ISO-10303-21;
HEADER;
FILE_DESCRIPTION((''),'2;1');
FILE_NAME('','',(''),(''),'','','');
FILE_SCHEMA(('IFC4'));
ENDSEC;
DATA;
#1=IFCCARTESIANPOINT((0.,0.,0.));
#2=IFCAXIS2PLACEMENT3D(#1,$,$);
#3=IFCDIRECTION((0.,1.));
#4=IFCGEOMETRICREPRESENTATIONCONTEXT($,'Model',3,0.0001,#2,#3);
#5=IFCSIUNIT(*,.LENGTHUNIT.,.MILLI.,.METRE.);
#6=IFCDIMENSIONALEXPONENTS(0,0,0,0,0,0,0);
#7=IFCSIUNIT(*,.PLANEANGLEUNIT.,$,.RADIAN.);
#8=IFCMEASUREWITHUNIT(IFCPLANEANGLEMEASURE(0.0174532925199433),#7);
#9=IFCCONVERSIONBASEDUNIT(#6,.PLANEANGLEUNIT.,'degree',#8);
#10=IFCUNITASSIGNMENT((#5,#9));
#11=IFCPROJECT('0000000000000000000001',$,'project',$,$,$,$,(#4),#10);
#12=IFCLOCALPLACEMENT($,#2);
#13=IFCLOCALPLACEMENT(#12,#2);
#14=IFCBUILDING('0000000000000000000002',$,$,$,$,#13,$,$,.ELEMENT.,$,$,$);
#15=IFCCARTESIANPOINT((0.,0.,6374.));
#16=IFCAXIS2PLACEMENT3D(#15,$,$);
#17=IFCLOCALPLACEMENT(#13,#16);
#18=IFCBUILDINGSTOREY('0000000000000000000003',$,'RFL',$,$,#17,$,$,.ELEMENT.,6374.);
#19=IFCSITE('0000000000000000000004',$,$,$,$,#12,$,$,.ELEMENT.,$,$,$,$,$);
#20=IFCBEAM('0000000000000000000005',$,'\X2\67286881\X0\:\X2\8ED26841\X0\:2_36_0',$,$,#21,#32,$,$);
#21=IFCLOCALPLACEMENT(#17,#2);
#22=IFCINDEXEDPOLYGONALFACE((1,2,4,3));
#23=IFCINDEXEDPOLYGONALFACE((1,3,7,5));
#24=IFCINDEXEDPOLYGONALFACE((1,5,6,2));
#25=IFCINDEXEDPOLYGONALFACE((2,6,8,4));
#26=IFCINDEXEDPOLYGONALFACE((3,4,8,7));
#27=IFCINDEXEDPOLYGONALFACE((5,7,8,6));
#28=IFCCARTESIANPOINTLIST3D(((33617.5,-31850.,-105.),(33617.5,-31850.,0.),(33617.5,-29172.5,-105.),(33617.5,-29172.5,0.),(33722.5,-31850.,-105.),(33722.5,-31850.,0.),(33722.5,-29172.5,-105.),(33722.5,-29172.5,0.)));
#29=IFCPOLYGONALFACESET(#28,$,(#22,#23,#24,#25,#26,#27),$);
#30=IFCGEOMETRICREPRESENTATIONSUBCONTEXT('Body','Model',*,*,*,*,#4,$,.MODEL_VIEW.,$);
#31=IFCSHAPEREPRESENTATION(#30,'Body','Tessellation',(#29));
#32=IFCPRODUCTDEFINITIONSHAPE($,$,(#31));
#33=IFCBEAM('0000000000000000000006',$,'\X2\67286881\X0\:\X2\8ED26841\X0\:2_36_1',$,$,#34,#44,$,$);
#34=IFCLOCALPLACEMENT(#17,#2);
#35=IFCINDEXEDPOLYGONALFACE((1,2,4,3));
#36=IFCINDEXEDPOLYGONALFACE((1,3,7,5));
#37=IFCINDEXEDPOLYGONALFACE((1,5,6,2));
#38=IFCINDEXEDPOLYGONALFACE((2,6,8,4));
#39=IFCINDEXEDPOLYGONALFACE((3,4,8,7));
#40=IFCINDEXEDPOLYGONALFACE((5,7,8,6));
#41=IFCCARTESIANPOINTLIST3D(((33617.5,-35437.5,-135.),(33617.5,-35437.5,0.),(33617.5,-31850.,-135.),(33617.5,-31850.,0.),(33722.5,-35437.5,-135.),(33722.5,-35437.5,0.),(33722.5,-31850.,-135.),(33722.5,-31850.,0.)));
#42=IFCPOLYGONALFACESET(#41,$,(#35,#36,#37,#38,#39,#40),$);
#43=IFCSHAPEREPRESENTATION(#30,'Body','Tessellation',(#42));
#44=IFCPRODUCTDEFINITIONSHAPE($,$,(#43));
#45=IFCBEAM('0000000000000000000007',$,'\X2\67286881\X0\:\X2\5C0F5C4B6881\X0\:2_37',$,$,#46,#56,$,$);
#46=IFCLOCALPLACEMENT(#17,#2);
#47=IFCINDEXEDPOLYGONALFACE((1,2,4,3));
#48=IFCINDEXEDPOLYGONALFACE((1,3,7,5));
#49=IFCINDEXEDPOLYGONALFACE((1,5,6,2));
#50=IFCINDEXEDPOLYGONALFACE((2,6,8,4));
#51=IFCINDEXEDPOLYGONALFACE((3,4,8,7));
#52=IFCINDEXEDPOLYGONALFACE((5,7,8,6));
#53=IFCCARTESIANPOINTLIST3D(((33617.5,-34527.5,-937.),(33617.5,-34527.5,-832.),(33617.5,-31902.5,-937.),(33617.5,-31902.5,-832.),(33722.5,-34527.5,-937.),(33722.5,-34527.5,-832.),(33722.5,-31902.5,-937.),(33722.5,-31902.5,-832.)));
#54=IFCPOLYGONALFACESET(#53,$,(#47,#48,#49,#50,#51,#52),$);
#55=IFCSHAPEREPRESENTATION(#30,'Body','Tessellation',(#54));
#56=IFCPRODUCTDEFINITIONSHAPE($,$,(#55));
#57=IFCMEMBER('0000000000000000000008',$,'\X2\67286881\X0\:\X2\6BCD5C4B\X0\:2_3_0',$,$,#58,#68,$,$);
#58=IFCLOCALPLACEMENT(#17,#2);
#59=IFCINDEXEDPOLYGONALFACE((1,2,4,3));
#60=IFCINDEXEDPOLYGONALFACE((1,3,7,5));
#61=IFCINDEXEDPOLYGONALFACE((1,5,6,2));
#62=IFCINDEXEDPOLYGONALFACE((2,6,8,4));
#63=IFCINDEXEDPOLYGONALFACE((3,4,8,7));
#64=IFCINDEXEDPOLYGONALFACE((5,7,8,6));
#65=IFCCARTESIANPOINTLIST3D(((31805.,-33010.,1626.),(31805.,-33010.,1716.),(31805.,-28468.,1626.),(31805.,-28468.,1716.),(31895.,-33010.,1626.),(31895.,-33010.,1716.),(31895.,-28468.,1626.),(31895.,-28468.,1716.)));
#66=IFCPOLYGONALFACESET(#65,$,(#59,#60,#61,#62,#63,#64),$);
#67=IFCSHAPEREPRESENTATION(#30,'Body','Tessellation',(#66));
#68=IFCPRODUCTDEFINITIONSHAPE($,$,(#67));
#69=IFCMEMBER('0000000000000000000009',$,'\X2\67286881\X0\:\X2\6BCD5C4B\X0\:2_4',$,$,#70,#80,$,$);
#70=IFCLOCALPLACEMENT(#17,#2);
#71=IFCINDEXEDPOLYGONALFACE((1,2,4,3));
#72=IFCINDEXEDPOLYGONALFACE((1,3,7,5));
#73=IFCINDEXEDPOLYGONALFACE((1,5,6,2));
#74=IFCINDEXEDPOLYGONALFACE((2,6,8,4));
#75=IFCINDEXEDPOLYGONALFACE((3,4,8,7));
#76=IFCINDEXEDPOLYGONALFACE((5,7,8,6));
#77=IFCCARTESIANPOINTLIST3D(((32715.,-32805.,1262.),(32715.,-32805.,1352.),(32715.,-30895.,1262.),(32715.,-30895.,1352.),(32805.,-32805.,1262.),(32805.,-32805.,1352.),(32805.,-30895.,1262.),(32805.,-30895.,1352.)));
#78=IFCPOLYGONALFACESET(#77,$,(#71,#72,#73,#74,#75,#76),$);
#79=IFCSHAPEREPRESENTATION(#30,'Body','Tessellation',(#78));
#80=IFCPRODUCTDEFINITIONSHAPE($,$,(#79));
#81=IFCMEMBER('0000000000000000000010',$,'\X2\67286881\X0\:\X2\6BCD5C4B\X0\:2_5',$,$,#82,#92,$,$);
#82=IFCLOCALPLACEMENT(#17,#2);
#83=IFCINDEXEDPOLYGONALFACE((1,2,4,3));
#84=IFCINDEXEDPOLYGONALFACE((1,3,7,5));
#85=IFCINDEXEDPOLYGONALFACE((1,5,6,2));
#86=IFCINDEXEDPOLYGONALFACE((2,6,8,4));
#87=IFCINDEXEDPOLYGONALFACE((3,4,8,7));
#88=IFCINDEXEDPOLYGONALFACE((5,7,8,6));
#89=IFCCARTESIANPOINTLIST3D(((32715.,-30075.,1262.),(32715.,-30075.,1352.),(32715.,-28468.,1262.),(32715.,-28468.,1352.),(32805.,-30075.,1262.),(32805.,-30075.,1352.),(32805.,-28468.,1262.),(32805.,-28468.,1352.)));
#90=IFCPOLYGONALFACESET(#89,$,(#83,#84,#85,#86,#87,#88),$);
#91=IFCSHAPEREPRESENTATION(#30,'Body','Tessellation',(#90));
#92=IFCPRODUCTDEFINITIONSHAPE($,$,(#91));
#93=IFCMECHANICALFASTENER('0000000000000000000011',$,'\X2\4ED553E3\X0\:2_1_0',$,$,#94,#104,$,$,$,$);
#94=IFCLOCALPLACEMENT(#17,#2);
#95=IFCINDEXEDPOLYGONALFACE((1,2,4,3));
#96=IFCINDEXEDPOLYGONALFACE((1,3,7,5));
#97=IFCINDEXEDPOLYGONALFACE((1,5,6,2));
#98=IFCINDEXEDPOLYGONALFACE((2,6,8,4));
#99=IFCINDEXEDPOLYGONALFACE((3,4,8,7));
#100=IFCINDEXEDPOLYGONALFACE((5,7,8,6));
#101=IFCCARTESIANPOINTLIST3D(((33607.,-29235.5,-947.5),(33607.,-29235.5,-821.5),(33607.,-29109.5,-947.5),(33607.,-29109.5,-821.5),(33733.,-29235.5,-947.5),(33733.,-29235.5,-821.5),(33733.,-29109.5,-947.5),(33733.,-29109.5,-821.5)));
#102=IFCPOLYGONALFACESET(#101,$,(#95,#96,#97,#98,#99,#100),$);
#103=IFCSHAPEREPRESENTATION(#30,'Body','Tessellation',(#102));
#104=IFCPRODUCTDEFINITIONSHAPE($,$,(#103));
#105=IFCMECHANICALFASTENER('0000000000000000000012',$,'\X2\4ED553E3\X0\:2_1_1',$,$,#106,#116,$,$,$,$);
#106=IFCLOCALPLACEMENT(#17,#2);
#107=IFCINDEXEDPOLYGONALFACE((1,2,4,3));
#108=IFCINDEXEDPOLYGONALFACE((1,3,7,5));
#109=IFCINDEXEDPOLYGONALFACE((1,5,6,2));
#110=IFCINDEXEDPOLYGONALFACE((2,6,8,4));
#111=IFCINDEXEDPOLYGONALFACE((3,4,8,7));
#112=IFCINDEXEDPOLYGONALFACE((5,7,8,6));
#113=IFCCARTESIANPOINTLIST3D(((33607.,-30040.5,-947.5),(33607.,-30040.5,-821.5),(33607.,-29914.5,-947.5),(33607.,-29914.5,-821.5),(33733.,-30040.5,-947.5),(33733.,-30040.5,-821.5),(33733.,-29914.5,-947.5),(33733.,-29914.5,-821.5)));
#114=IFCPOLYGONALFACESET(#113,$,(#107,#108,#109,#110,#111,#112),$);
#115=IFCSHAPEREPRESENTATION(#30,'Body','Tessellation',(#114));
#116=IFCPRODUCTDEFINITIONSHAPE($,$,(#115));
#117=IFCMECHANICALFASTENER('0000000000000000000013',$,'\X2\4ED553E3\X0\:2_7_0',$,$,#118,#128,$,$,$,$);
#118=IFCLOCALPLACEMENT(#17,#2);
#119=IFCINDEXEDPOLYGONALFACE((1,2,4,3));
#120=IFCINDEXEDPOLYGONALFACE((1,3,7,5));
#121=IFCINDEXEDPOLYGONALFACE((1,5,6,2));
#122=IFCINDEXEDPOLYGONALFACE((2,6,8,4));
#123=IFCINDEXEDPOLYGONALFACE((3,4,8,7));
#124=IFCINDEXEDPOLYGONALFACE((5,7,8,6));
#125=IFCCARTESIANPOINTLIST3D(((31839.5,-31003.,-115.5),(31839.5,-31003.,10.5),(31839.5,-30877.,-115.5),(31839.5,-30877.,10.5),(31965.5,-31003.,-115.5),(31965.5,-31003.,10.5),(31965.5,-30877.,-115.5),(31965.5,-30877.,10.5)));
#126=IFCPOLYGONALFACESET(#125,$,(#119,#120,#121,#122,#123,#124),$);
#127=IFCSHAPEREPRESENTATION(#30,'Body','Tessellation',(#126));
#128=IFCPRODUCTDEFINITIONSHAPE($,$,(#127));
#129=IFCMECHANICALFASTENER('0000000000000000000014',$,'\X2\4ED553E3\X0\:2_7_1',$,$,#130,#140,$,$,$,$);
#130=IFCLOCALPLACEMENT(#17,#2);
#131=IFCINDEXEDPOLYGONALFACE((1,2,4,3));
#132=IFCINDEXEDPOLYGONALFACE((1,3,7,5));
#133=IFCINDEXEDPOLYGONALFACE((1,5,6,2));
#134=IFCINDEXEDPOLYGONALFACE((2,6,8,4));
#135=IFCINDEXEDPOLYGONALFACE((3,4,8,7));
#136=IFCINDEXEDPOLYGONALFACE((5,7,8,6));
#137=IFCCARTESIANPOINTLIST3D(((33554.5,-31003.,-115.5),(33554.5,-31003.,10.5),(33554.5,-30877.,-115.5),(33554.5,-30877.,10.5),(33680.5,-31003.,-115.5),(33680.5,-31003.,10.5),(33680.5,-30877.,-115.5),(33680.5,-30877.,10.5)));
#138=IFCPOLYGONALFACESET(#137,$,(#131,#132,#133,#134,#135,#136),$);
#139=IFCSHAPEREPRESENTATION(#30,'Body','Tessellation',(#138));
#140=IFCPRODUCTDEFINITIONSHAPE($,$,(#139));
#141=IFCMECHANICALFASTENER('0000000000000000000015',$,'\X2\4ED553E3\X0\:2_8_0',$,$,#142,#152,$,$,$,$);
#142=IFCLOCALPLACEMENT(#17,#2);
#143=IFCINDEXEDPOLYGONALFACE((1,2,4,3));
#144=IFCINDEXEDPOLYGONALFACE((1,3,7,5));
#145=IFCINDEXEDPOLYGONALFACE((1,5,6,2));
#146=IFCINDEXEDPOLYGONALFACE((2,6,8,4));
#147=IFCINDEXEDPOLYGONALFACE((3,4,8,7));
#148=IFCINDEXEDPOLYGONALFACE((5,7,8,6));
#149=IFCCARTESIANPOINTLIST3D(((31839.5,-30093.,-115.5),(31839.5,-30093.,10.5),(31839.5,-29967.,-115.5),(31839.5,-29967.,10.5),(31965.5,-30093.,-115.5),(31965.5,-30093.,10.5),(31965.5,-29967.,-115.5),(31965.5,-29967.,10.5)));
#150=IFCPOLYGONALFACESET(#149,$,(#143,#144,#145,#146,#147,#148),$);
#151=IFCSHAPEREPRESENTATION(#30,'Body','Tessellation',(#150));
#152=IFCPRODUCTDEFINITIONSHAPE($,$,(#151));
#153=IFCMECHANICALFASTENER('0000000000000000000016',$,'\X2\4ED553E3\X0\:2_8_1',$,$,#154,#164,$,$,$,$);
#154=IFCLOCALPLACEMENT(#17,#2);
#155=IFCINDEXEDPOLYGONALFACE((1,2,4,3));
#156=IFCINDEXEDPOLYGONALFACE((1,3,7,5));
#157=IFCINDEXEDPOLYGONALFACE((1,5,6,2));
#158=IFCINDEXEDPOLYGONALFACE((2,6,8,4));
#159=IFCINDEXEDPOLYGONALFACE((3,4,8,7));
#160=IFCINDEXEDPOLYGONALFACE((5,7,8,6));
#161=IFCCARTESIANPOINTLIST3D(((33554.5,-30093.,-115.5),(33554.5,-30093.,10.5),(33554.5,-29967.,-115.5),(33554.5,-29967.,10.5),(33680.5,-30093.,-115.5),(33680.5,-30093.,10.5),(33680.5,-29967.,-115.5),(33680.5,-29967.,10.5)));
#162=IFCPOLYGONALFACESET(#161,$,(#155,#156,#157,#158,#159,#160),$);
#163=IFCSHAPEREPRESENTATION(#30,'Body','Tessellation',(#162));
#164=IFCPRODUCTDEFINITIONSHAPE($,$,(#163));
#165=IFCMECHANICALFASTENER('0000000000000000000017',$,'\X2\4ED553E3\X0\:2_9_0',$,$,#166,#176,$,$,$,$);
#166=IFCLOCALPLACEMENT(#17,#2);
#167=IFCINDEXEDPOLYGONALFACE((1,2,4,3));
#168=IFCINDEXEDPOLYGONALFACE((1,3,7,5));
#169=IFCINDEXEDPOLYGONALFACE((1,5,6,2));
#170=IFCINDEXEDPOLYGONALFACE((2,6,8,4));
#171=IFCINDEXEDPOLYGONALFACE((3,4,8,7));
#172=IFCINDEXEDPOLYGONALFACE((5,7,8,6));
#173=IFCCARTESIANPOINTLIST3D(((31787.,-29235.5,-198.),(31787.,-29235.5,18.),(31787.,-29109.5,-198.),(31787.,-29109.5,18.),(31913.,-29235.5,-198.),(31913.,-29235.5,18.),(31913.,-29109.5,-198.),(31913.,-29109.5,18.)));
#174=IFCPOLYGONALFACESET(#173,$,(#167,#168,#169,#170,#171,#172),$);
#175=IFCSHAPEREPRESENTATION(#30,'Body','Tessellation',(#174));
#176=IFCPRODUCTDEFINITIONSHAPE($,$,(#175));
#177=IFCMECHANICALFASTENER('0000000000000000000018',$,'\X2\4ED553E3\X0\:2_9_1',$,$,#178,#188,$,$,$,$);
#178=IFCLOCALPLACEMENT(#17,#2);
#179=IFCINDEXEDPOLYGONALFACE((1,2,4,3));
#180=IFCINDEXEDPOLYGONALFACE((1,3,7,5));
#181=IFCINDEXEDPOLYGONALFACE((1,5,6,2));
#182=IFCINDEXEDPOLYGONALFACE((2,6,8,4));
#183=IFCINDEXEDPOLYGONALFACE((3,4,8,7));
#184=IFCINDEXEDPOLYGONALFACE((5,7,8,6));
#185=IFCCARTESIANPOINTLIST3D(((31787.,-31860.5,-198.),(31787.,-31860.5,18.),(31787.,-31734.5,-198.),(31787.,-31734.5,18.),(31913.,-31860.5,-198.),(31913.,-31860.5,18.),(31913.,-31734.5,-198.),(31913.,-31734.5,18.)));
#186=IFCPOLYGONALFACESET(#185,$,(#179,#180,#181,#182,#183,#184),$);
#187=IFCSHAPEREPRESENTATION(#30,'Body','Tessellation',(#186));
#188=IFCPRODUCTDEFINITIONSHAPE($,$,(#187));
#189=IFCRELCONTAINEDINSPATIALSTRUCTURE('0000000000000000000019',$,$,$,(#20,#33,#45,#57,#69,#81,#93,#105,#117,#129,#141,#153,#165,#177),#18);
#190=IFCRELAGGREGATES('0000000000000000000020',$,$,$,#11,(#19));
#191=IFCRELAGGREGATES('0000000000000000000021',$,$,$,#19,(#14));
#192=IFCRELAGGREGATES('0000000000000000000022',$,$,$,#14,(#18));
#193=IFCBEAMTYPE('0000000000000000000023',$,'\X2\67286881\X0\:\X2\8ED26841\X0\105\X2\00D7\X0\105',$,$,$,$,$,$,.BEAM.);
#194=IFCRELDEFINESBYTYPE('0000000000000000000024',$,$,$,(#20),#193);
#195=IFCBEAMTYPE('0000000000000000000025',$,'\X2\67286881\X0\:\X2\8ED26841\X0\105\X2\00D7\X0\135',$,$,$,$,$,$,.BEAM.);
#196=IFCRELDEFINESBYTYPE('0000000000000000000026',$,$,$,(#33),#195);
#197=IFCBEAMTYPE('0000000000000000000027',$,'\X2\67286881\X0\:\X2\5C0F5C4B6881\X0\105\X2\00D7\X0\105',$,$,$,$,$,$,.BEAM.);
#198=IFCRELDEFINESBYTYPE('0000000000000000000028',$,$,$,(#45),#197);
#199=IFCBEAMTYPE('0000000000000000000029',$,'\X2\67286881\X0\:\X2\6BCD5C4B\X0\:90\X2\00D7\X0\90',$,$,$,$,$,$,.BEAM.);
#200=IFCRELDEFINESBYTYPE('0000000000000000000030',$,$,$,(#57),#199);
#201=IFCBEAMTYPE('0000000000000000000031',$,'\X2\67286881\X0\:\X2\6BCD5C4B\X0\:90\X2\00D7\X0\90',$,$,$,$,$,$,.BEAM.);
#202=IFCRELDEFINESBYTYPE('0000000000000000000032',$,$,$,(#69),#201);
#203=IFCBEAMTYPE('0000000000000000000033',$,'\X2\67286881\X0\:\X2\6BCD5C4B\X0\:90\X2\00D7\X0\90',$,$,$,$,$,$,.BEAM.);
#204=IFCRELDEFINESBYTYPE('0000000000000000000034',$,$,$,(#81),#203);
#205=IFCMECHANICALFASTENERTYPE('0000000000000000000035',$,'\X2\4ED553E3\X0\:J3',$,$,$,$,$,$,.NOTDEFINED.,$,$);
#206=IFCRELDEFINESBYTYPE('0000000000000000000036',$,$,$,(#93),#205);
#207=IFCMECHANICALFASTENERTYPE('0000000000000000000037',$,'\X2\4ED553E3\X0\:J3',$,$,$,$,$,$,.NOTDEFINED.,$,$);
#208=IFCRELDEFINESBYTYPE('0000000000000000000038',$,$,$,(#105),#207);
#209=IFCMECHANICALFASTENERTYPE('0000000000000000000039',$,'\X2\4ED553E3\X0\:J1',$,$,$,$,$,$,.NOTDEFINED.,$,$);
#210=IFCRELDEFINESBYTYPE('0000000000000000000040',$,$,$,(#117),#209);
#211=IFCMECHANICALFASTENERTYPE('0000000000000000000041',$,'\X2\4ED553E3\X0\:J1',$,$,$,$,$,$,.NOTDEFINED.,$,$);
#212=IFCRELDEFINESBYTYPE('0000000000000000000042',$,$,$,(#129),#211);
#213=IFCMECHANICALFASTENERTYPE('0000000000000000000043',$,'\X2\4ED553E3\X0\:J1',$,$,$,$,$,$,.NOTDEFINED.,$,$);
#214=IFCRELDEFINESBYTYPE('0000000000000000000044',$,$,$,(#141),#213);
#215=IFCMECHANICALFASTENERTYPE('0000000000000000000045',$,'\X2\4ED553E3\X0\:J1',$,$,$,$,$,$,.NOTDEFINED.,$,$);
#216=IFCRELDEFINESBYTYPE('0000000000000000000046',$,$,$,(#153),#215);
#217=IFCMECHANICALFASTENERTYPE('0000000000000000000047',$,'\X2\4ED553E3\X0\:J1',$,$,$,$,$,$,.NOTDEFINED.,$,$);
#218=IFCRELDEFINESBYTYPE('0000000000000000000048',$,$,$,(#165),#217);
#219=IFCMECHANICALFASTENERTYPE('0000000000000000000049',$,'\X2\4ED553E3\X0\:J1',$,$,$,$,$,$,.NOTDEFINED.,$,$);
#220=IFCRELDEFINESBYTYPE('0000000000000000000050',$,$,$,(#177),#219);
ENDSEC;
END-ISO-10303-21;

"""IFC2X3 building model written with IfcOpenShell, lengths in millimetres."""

from ifc_helpers import new_model, entity, si_unit, converted_unit, direction, frame, origin, origin_with_axes, origin_2d, place, context, subcontext, project, spatial, rectangle, extrude, type_object, element, save


model = new_model("IFC2X3")

# Units and contexts
model_context = context("Model", 3, precision=0.0001, world=origin(), true_north=direction((0.0, 1.0)))
body_context = subcontext(model_context, "Body", "Model", "MODEL_VIEW")
ifc_project = project(units=[si_unit("LENGTHUNIT", "METRE", prefix="MILLI"), converted_unit("PLANEANGLEUNIT", "degree", entity("IfcPlaneAngleMeasure", 0.0174532925199433), si_unit("PLANEANGLEUNIT", "RADIAN"), dimensions=[0, 0, 0, 0, 0, 0, 0])], contexts=[model_context])

# Site, building, storey
site_placement = place(None, origin())
site = spatial("IfcSite", under=ifc_project, at=site_placement, CompositionType="ELEMENT")
building_placement = place(site_placement, origin())
building = spatial("IfcBuilding", under=site, at=building_placement, CompositionType="ELEMENT")
storey_placement = place(building_placement, frame((0.0, 0.0, 6374.0)))
storey = spatial("IfcBuildingStorey", under=building, at=storey_placement, Name="RFL", CompositionType="ELEMENT", Elevation=6374.0)

# Beams
beam_type_1 = type_object("IfcBeamType", Name="木梁:軒桁105×105", PredefinedType="BEAM")
beam_1_placement = place(storey_placement, frame((33670.0, -29172.5, -52.5), z_axis=(0.0, -1.0, 0.0), x_axis=(1.0, 0.0, 0.0)))
element("IfcBeam", 1, at=beam_1_placement, inside=storey, type_object=beam_type_1, Name="木梁:軒桁:2_36_0", context=body_context, shape_type="SweptSolid", body=[
    extrude(rectangle(XDim=105.0, YDim=105.0, at=origin_2d()), origin_with_axes(), (0.0, 0.0, 1.0), 2677.5),
])
beam_type_2 = type_object("IfcBeamType", Name="木梁:軒桁105×135", PredefinedType="BEAM")
beam_2_placement = place(storey_placement, frame((33670.0, -31850.0, -67.5), z_axis=(0.0, -1.0, 0.0), x_axis=(1.0, 0.0, 0.0)))
element("IfcBeam", 2, at=beam_2_placement, inside=storey, type_object=beam_type_2, Name="木梁:軒桁:2_36_1", context=body_context, shape_type="SweptSolid", body=[
    extrude(rectangle(XDim=105.0, YDim=135.0, at=origin_2d()), origin_with_axes(), (0.0, 0.0, 1.0), 3587.5),
])
beam_type_3 = type_object("IfcBeamType", Name="木梁:小屋梁105×105", PredefinedType="BEAM")
beam_3_placement = place(storey_placement, frame((33670.0, -31902.5, -884.5), z_axis=(0.0, -1.0, 0.0), x_axis=(1.0, 0.0, 0.0)))
element("IfcBeam", 3, at=beam_3_placement, inside=storey, type_object=beam_type_3, Name="木梁:小屋梁:2_37", context=body_context, shape_type="SweptSolid", body=[
    extrude(rectangle(XDim=105.0, YDim=105.0, at=origin_2d()), origin_with_axes(), (0.0, 0.0, 1.0), 2625.0),
])

# Members
beam_type_4 = type_object("IfcBeamType", Name="木梁:母屋:90×90", PredefinedType="BEAM")
member_1_placement = place(storey_placement, frame((31850.0, -28468.0, 1671.0), z_axis=(0.0, -1.0, 0.0), x_axis=(-1.0, 0.0, 0.0)))
element("IfcMember", 4, at=member_1_placement, inside=storey, type_object=beam_type_4, Name="木梁:母屋:2_3_0", context=body_context, shape_type="SweptSolid", body=[
    extrude(rectangle(XDim=90.0, YDim=90.0, at=origin_2d()), origin_with_axes(), (0.0, 0.0, 1.0), 4542.0),
])
beam_type_5 = type_object("IfcBeamType", Name="木梁:母屋:90×90", PredefinedType="BEAM")
member_2_placement = place(storey_placement, frame((32760.0, -30895.0, 1307.0), z_axis=(0.0, -1.0, 0.0), x_axis=(-1.0, 0.0, 0.0)))
element("IfcMember", 5, at=member_2_placement, inside=storey, type_object=beam_type_5, Name="木梁:母屋:2_4", context=body_context, shape_type="SweptSolid", body=[
    extrude(rectangle(XDim=90.0, YDim=90.0, at=origin_2d()), origin_with_axes(), (0.0, 0.0, 1.0), 1910.0),
])
beam_type_6 = type_object("IfcBeamType", Name="木梁:母屋:90×90", PredefinedType="BEAM")
member_3_placement = place(storey_placement, frame((32760.0, -28468.0, 1307.0), z_axis=(0.0, -1.0, 0.0), x_axis=(-1.0, 0.0, 0.0)))
element("IfcMember", 6, at=member_3_placement, inside=storey, type_object=beam_type_6, Name="木梁:母屋:2_5", context=body_context, shape_type="SweptSolid", body=[
    extrude(rectangle(XDim=90.0, YDim=90.0, at=origin_2d()), origin_with_axes(), (0.0, 0.0, 1.0), 1607.0),
])

# Mechanical fasteners
mechanical_fastener_type_1 = type_object("IfcMechanicalFastenerType", Name="仕口:J3")
mechanical_fastener_1_placement = place(storey_placement, frame((33670.0, -29172.5, -947.5)))
element("IfcMechanicalFastener", 7, at=mechanical_fastener_1_placement, inside=storey, type_object=mechanical_fastener_type_1, Name="仕口:2_1_0", context=body_context, shape_type="SweptSolid", body=[
    extrude(rectangle(XDim=126.0, YDim=126.0, at=origin_2d()), origin_with_axes(), (0.0, 0.0, 1.0), 126.0),
])
mechanical_fastener_type_2 = type_object("IfcMechanicalFastenerType", Name="仕口:J3")
mechanical_fastener_2_placement = place(storey_placement, frame((33670.0, -29977.5, -947.5)))
element("IfcMechanicalFastener", 8, at=mechanical_fastener_2_placement, inside=storey, type_object=mechanical_fastener_type_2, Name="仕口:2_1_1", context=body_context, shape_type="SweptSolid", body=[
    extrude(rectangle(XDim=126.0, YDim=126.0, at=origin_2d()), origin_with_axes(), (0.0, 0.0, 1.0), 126.0),
])
mechanical_fastener_type_3 = type_object("IfcMechanicalFastenerType", Name="仕口:J1")
mechanical_fastener_3_placement = place(storey_placement, frame((31902.5, -30940.0, -115.5)))
element("IfcMechanicalFastener", 9, at=mechanical_fastener_3_placement, inside=storey, type_object=mechanical_fastener_type_3, Name="仕口:2_7_0", context=body_context, shape_type="SweptSolid", body=[
    extrude(rectangle(XDim=126.0, YDim=126.0, at=origin_2d()), origin_with_axes(), (0.0, 0.0, 1.0), 126.0),
])
mechanical_fastener_type_4 = type_object("IfcMechanicalFastenerType", Name="仕口:J1")
mechanical_fastener_4_placement = place(storey_placement, frame((33617.5, -30940.0, -115.5)))
element("IfcMechanicalFastener", 10, at=mechanical_fastener_4_placement, inside=storey, type_object=mechanical_fastener_type_4, Name="仕口:2_7_1", context=body_context, shape_type="SweptSolid", body=[
    extrude(rectangle(XDim=126.0, YDim=126.0, at=origin_2d()), origin_with_axes(), (0.0, 0.0, 1.0), 126.0),
])
mechanical_fastener_type_5 = type_object("IfcMechanicalFastenerType", Name="仕口:J1")
mechanical_fastener_5_placement = place(storey_placement, frame((31902.5, -30030.0, -115.5)))
element("IfcMechanicalFastener", 11, at=mechanical_fastener_5_placement, inside=storey, type_object=mechanical_fastener_type_5, Name="仕口:2_8_0", context=body_context, shape_type="SweptSolid", body=[
    extrude(rectangle(XDim=126.0, YDim=126.0, at=origin_2d()), origin_with_axes(), (0.0, 0.0, 1.0), 126.0),
])
mechanical_fastener_type_6 = type_object("IfcMechanicalFastenerType", Name="仕口:J1")
mechanical_fastener_6_placement = place(storey_placement, frame((33617.5, -30030.0, -115.5)))
element("IfcMechanicalFastener", 12, at=mechanical_fastener_6_placement, inside=storey, type_object=mechanical_fastener_type_6, Name="仕口:2_8_1", context=body_context, shape_type="SweptSolid", body=[
    extrude(rectangle(XDim=126.0, YDim=126.0, at=origin_2d()), origin_with_axes(), (0.0, 0.0, 1.0), 126.0),
])
mechanical_fastener_type_7 = type_object("IfcMechanicalFastenerType", Name="仕口:J1")
mechanical_fastener_7_placement = place(storey_placement, frame((31850.0, -29172.5, -198.0)))
element("IfcMechanicalFastener", 13, at=mechanical_fastener_7_placement, inside=storey, type_object=mechanical_fastener_type_7, Name="仕口:2_9_0", context=body_context, shape_type="SweptSolid", body=[
    extrude(rectangle(XDim=126.0, YDim=126.0, at=origin_2d()), origin_with_axes(), (0.0, 0.0, 1.0), 216.0),
])
mechanical_fastener_type_8 = type_object("IfcMechanicalFastenerType", Name="仕口:J1")
mechanical_fastener_8_placement = place(storey_placement, frame((31850.0, -31797.5, -198.0)))
element("IfcMechanicalFastener", 14, at=mechanical_fastener_8_placement, inside=storey, type_object=mechanical_fastener_type_8, Name="仕口:2_9_1", context=body_context, shape_type="SweptSolid", body=[
    extrude(rectangle(XDim=126.0, YDim=126.0, at=origin_2d()), origin_with_axes(), (0.0, 0.0, 1.0), 216.0),
])

save(model, "model.ifc")
